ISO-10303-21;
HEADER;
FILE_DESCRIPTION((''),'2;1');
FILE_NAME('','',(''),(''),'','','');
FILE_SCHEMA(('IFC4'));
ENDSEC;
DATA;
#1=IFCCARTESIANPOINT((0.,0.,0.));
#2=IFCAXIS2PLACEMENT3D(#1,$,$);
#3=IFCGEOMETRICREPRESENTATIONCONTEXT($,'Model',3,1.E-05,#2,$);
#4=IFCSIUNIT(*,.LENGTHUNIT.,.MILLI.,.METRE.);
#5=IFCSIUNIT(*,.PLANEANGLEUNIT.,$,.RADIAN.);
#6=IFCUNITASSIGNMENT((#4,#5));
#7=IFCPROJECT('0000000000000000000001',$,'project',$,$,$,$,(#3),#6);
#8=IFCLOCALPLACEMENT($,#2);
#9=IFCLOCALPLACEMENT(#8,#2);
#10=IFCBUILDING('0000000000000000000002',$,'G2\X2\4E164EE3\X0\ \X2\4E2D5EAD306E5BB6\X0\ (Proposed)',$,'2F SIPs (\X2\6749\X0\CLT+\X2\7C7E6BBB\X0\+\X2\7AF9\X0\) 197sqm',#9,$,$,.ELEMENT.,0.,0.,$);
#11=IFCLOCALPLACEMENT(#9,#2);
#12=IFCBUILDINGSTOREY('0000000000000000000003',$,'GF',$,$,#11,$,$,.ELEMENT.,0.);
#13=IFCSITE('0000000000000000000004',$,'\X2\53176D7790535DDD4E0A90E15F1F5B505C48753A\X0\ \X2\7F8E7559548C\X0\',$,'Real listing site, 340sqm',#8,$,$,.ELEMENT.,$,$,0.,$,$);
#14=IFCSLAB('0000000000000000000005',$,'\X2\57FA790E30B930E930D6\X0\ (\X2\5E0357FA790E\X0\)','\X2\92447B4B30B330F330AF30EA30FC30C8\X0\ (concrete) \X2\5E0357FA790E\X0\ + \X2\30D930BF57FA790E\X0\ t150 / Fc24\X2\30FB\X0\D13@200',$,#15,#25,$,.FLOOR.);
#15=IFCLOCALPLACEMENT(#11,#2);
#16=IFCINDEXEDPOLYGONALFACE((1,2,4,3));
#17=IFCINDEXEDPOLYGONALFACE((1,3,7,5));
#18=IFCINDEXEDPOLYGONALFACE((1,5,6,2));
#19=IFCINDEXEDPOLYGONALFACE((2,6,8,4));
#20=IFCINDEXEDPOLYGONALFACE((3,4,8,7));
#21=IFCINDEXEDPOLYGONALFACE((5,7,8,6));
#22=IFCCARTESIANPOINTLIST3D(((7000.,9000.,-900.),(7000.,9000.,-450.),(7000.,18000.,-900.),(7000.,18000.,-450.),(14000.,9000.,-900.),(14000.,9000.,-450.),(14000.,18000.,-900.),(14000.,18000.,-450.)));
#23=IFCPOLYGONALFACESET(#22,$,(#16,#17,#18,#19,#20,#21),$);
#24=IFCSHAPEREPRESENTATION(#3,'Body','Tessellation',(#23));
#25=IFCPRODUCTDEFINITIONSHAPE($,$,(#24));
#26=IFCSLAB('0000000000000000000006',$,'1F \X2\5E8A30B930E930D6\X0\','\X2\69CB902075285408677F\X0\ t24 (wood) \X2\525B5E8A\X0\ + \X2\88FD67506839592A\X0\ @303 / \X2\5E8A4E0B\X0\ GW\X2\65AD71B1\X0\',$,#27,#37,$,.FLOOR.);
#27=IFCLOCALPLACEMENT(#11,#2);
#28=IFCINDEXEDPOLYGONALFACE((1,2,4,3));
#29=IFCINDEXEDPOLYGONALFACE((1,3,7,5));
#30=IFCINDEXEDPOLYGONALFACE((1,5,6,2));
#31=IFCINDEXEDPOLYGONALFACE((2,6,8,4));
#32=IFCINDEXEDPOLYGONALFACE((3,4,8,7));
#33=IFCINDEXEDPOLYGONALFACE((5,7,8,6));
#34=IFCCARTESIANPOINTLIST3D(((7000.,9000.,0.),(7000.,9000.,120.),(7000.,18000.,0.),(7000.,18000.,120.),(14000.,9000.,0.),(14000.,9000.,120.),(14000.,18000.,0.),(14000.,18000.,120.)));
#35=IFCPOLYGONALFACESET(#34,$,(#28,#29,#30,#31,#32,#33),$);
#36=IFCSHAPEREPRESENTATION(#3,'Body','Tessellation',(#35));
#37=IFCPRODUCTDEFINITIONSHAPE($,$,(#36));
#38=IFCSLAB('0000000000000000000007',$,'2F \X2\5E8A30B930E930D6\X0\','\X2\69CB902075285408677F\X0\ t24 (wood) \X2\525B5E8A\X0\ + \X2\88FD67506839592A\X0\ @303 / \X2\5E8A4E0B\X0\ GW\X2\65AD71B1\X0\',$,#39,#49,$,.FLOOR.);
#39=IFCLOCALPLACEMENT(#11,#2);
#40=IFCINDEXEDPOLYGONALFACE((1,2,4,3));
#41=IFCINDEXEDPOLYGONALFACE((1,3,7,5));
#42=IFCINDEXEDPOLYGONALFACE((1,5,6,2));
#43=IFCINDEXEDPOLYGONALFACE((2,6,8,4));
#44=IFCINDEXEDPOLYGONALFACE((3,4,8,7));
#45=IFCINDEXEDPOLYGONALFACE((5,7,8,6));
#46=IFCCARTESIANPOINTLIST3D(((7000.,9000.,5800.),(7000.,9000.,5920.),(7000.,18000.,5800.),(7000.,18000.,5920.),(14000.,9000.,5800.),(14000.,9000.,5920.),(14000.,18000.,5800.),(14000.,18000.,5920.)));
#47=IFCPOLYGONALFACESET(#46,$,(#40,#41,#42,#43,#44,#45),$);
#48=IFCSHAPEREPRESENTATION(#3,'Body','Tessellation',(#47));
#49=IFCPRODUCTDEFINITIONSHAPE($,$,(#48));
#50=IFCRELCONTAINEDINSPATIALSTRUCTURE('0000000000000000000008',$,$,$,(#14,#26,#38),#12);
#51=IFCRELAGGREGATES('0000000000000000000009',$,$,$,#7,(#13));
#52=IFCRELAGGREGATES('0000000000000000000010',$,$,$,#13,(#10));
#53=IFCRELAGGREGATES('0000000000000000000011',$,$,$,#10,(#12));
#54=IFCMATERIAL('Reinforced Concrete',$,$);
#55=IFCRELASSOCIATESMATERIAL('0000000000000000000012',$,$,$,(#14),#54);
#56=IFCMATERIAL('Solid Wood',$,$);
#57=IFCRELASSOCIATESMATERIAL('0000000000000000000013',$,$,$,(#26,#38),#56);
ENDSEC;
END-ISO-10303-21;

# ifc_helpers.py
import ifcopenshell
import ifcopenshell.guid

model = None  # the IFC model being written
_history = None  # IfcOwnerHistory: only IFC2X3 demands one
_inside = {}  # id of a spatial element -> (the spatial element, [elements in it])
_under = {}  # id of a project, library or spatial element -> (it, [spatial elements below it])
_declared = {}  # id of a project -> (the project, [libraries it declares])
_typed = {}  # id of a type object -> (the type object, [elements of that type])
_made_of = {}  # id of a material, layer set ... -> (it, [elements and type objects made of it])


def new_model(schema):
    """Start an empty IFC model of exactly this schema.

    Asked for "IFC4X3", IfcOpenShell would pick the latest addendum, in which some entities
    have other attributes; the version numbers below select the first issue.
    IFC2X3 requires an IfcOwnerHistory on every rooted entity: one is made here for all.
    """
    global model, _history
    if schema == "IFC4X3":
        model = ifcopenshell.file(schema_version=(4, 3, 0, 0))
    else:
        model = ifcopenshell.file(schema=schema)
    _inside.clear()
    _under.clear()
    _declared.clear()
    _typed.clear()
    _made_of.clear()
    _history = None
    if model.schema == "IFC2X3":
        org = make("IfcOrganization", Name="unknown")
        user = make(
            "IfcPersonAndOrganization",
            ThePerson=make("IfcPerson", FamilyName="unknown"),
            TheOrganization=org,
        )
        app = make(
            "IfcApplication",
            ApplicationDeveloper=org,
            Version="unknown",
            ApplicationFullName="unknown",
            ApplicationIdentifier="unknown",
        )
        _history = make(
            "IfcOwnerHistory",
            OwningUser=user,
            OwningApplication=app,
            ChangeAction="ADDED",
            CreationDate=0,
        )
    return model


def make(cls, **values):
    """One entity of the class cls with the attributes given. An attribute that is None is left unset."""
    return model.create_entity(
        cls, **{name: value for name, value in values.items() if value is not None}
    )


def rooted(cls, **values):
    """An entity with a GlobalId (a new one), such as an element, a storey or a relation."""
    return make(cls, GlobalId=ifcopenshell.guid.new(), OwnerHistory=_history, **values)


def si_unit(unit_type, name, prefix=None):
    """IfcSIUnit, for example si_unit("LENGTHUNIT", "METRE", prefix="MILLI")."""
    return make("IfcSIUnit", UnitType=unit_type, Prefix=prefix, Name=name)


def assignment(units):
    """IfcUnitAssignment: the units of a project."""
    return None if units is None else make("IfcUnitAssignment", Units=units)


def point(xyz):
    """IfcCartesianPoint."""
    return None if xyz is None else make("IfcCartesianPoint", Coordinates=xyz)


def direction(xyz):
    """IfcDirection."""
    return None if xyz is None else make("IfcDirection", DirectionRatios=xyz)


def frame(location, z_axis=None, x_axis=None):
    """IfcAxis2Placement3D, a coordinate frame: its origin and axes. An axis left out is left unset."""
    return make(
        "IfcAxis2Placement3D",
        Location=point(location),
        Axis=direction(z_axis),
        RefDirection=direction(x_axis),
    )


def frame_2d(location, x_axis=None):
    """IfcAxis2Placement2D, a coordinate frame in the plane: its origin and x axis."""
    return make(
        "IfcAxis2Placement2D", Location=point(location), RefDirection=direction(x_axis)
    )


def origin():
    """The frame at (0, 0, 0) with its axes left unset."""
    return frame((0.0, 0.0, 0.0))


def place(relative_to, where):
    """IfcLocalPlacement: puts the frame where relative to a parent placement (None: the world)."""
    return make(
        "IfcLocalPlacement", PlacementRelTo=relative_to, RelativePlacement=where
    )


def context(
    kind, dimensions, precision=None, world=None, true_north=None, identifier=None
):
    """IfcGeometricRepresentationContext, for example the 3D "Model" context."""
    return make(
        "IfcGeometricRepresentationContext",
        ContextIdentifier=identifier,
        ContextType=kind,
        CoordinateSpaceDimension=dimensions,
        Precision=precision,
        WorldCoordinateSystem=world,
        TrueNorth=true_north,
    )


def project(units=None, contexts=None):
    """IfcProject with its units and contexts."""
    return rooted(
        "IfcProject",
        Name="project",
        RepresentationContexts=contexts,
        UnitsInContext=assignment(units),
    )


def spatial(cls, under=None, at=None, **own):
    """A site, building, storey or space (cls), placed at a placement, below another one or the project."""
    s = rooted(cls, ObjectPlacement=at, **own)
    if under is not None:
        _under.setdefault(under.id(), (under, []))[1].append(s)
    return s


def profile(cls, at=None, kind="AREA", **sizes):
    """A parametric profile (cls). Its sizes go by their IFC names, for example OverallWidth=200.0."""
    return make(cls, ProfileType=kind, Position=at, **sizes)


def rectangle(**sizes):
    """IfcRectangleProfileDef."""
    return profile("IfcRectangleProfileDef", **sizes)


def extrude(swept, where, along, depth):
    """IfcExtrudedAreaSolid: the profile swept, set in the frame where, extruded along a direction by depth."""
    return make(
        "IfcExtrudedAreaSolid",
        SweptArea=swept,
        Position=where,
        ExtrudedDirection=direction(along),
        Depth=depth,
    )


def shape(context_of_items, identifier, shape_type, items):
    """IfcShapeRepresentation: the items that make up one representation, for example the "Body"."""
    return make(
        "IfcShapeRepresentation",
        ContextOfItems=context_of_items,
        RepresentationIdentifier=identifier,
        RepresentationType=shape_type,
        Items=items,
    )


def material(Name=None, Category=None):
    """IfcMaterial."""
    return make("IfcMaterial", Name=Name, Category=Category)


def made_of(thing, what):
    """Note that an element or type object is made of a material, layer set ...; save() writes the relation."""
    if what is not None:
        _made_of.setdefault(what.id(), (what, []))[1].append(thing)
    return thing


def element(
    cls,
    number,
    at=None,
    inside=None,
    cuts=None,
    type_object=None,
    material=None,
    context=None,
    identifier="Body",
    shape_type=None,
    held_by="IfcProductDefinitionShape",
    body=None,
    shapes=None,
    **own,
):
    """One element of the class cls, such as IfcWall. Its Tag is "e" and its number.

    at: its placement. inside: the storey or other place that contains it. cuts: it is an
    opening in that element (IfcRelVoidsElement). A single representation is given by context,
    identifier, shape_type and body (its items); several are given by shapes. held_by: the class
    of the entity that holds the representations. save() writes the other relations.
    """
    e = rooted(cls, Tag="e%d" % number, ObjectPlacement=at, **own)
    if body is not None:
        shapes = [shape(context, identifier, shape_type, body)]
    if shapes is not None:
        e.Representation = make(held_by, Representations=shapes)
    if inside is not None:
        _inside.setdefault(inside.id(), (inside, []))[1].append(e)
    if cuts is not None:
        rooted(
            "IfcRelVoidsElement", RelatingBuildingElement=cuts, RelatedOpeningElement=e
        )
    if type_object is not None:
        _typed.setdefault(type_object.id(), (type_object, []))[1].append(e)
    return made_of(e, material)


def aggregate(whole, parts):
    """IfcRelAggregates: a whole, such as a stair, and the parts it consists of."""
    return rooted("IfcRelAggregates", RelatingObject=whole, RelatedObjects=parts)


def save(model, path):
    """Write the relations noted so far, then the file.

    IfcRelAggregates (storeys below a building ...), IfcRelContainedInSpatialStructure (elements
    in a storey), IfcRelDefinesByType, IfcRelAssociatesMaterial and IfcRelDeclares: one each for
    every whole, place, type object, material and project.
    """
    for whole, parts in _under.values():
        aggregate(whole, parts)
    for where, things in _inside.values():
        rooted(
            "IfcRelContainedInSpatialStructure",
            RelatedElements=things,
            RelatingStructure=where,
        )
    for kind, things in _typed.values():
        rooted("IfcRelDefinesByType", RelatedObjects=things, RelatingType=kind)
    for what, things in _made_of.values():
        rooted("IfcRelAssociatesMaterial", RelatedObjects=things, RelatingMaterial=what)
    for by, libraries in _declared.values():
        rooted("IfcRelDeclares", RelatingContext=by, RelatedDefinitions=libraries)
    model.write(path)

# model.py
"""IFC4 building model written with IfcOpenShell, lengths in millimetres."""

from ifc_helpers import new_model, si_unit, frame, frame_2d, origin, place, context, project, spatial, rectangle, extrude, material, element, save


model = new_model("IFC4")

# Units and contexts
model_context = context("Model", 3, precision=1e-05, world=origin())
ifc_project = project(units=[si_unit("LENGTHUNIT", "METRE", prefix="MILLI"), si_unit("PLANEANGLEUNIT", "RADIAN")], contexts=[model_context])

# Site, building, storey
site_placement = place(None, origin())
site = spatial("IfcSite", under=ifc_project, at=site_placement, Name="北海道川上郡弟子屈町 美留和", ObjectType="Real listing site, 340sqm", CompositionType="ELEMENT", RefElevation=0.0)
building_placement = place(site_placement, origin())
building = spatial("IfcBuilding", under=site, at=building_placement, Name="G2世代 中庭の家 (Proposed)", ObjectType="2F SIPs (杉CLT+籾殻+竹) 197sqm", CompositionType="ELEMENT", ElevationOfRefHeight=0.0, ElevationOfTerrain=0.0)
storey_placement = place(building_placement, origin())
storey = spatial("IfcBuildingStorey", under=building, at=storey_placement, Name="GF", CompositionType="ELEMENT", Elevation=0.0)

# Slabs
ifc_material_1 = material(Name="Reinforced Concrete")
slab_1_placement = place(storey_placement, frame((3500.0, 4500.0, -450.0)))
element("IfcSlab", 1, at=slab_1_placement, inside=storey, material=ifc_material_1, Name="基礎スラブ (布基礎)", Description="鉄筋コンクリート (concrete) 布基礎 + ベタ基礎 t150 / Fc24・D13@200", PredefinedType="FLOOR", context=model_context, shape_type="SweptSolid", body=[
    extrude(rectangle(XDim=7000.0, YDim=9000.0, at=frame_2d((3500.0, 4500.0))), frame((3500.0, 4500.0, -450.0)), (0.0, 0.0, 1.0), 450.0),
])
ifc_material_2 = material(Name="Solid Wood")
slab_2_placement = place(storey_placement, frame((3500.0, 4500.0, 0.0)))
element("IfcSlab", 2, at=slab_2_placement, inside=storey, material=ifc_material_2, Name="1F 床スラブ", Description="構造用合板 t24 (wood) 剛床 + 製材根太 @303 / 床下 GW断熱", PredefinedType="FLOOR", context=model_context, shape_type="SweptSolid", body=[
    extrude(rectangle(XDim=7000.0, YDim=9000.0, at=frame_2d((3500.0, 4500.0))), frame((3500.0, 4500.0, 0.0)), (0.0, 0.0, 1.0), 120.0),
])
slab_3_placement = place(storey_placement, frame((3500.0, 4500.0, 2900.0)))
element("IfcSlab", 3, at=slab_3_placement, inside=storey, material=ifc_material_2, Name="2F 床スラブ", Description="構造用合板 t24 (wood) 剛床 + 製材根太 @303 / 床下 GW断熱", PredefinedType="FLOOR", context=model_context, shape_type="SweptSolid", body=[
    extrude(rectangle(XDim=7000.0, YDim=9000.0, at=frame_2d((3500.0, 4500.0))), frame((3500.0, 4500.0, 2900.0)), (0.0, 0.0, 1.0), 120.0),
])

save(model, "model.ifc")
